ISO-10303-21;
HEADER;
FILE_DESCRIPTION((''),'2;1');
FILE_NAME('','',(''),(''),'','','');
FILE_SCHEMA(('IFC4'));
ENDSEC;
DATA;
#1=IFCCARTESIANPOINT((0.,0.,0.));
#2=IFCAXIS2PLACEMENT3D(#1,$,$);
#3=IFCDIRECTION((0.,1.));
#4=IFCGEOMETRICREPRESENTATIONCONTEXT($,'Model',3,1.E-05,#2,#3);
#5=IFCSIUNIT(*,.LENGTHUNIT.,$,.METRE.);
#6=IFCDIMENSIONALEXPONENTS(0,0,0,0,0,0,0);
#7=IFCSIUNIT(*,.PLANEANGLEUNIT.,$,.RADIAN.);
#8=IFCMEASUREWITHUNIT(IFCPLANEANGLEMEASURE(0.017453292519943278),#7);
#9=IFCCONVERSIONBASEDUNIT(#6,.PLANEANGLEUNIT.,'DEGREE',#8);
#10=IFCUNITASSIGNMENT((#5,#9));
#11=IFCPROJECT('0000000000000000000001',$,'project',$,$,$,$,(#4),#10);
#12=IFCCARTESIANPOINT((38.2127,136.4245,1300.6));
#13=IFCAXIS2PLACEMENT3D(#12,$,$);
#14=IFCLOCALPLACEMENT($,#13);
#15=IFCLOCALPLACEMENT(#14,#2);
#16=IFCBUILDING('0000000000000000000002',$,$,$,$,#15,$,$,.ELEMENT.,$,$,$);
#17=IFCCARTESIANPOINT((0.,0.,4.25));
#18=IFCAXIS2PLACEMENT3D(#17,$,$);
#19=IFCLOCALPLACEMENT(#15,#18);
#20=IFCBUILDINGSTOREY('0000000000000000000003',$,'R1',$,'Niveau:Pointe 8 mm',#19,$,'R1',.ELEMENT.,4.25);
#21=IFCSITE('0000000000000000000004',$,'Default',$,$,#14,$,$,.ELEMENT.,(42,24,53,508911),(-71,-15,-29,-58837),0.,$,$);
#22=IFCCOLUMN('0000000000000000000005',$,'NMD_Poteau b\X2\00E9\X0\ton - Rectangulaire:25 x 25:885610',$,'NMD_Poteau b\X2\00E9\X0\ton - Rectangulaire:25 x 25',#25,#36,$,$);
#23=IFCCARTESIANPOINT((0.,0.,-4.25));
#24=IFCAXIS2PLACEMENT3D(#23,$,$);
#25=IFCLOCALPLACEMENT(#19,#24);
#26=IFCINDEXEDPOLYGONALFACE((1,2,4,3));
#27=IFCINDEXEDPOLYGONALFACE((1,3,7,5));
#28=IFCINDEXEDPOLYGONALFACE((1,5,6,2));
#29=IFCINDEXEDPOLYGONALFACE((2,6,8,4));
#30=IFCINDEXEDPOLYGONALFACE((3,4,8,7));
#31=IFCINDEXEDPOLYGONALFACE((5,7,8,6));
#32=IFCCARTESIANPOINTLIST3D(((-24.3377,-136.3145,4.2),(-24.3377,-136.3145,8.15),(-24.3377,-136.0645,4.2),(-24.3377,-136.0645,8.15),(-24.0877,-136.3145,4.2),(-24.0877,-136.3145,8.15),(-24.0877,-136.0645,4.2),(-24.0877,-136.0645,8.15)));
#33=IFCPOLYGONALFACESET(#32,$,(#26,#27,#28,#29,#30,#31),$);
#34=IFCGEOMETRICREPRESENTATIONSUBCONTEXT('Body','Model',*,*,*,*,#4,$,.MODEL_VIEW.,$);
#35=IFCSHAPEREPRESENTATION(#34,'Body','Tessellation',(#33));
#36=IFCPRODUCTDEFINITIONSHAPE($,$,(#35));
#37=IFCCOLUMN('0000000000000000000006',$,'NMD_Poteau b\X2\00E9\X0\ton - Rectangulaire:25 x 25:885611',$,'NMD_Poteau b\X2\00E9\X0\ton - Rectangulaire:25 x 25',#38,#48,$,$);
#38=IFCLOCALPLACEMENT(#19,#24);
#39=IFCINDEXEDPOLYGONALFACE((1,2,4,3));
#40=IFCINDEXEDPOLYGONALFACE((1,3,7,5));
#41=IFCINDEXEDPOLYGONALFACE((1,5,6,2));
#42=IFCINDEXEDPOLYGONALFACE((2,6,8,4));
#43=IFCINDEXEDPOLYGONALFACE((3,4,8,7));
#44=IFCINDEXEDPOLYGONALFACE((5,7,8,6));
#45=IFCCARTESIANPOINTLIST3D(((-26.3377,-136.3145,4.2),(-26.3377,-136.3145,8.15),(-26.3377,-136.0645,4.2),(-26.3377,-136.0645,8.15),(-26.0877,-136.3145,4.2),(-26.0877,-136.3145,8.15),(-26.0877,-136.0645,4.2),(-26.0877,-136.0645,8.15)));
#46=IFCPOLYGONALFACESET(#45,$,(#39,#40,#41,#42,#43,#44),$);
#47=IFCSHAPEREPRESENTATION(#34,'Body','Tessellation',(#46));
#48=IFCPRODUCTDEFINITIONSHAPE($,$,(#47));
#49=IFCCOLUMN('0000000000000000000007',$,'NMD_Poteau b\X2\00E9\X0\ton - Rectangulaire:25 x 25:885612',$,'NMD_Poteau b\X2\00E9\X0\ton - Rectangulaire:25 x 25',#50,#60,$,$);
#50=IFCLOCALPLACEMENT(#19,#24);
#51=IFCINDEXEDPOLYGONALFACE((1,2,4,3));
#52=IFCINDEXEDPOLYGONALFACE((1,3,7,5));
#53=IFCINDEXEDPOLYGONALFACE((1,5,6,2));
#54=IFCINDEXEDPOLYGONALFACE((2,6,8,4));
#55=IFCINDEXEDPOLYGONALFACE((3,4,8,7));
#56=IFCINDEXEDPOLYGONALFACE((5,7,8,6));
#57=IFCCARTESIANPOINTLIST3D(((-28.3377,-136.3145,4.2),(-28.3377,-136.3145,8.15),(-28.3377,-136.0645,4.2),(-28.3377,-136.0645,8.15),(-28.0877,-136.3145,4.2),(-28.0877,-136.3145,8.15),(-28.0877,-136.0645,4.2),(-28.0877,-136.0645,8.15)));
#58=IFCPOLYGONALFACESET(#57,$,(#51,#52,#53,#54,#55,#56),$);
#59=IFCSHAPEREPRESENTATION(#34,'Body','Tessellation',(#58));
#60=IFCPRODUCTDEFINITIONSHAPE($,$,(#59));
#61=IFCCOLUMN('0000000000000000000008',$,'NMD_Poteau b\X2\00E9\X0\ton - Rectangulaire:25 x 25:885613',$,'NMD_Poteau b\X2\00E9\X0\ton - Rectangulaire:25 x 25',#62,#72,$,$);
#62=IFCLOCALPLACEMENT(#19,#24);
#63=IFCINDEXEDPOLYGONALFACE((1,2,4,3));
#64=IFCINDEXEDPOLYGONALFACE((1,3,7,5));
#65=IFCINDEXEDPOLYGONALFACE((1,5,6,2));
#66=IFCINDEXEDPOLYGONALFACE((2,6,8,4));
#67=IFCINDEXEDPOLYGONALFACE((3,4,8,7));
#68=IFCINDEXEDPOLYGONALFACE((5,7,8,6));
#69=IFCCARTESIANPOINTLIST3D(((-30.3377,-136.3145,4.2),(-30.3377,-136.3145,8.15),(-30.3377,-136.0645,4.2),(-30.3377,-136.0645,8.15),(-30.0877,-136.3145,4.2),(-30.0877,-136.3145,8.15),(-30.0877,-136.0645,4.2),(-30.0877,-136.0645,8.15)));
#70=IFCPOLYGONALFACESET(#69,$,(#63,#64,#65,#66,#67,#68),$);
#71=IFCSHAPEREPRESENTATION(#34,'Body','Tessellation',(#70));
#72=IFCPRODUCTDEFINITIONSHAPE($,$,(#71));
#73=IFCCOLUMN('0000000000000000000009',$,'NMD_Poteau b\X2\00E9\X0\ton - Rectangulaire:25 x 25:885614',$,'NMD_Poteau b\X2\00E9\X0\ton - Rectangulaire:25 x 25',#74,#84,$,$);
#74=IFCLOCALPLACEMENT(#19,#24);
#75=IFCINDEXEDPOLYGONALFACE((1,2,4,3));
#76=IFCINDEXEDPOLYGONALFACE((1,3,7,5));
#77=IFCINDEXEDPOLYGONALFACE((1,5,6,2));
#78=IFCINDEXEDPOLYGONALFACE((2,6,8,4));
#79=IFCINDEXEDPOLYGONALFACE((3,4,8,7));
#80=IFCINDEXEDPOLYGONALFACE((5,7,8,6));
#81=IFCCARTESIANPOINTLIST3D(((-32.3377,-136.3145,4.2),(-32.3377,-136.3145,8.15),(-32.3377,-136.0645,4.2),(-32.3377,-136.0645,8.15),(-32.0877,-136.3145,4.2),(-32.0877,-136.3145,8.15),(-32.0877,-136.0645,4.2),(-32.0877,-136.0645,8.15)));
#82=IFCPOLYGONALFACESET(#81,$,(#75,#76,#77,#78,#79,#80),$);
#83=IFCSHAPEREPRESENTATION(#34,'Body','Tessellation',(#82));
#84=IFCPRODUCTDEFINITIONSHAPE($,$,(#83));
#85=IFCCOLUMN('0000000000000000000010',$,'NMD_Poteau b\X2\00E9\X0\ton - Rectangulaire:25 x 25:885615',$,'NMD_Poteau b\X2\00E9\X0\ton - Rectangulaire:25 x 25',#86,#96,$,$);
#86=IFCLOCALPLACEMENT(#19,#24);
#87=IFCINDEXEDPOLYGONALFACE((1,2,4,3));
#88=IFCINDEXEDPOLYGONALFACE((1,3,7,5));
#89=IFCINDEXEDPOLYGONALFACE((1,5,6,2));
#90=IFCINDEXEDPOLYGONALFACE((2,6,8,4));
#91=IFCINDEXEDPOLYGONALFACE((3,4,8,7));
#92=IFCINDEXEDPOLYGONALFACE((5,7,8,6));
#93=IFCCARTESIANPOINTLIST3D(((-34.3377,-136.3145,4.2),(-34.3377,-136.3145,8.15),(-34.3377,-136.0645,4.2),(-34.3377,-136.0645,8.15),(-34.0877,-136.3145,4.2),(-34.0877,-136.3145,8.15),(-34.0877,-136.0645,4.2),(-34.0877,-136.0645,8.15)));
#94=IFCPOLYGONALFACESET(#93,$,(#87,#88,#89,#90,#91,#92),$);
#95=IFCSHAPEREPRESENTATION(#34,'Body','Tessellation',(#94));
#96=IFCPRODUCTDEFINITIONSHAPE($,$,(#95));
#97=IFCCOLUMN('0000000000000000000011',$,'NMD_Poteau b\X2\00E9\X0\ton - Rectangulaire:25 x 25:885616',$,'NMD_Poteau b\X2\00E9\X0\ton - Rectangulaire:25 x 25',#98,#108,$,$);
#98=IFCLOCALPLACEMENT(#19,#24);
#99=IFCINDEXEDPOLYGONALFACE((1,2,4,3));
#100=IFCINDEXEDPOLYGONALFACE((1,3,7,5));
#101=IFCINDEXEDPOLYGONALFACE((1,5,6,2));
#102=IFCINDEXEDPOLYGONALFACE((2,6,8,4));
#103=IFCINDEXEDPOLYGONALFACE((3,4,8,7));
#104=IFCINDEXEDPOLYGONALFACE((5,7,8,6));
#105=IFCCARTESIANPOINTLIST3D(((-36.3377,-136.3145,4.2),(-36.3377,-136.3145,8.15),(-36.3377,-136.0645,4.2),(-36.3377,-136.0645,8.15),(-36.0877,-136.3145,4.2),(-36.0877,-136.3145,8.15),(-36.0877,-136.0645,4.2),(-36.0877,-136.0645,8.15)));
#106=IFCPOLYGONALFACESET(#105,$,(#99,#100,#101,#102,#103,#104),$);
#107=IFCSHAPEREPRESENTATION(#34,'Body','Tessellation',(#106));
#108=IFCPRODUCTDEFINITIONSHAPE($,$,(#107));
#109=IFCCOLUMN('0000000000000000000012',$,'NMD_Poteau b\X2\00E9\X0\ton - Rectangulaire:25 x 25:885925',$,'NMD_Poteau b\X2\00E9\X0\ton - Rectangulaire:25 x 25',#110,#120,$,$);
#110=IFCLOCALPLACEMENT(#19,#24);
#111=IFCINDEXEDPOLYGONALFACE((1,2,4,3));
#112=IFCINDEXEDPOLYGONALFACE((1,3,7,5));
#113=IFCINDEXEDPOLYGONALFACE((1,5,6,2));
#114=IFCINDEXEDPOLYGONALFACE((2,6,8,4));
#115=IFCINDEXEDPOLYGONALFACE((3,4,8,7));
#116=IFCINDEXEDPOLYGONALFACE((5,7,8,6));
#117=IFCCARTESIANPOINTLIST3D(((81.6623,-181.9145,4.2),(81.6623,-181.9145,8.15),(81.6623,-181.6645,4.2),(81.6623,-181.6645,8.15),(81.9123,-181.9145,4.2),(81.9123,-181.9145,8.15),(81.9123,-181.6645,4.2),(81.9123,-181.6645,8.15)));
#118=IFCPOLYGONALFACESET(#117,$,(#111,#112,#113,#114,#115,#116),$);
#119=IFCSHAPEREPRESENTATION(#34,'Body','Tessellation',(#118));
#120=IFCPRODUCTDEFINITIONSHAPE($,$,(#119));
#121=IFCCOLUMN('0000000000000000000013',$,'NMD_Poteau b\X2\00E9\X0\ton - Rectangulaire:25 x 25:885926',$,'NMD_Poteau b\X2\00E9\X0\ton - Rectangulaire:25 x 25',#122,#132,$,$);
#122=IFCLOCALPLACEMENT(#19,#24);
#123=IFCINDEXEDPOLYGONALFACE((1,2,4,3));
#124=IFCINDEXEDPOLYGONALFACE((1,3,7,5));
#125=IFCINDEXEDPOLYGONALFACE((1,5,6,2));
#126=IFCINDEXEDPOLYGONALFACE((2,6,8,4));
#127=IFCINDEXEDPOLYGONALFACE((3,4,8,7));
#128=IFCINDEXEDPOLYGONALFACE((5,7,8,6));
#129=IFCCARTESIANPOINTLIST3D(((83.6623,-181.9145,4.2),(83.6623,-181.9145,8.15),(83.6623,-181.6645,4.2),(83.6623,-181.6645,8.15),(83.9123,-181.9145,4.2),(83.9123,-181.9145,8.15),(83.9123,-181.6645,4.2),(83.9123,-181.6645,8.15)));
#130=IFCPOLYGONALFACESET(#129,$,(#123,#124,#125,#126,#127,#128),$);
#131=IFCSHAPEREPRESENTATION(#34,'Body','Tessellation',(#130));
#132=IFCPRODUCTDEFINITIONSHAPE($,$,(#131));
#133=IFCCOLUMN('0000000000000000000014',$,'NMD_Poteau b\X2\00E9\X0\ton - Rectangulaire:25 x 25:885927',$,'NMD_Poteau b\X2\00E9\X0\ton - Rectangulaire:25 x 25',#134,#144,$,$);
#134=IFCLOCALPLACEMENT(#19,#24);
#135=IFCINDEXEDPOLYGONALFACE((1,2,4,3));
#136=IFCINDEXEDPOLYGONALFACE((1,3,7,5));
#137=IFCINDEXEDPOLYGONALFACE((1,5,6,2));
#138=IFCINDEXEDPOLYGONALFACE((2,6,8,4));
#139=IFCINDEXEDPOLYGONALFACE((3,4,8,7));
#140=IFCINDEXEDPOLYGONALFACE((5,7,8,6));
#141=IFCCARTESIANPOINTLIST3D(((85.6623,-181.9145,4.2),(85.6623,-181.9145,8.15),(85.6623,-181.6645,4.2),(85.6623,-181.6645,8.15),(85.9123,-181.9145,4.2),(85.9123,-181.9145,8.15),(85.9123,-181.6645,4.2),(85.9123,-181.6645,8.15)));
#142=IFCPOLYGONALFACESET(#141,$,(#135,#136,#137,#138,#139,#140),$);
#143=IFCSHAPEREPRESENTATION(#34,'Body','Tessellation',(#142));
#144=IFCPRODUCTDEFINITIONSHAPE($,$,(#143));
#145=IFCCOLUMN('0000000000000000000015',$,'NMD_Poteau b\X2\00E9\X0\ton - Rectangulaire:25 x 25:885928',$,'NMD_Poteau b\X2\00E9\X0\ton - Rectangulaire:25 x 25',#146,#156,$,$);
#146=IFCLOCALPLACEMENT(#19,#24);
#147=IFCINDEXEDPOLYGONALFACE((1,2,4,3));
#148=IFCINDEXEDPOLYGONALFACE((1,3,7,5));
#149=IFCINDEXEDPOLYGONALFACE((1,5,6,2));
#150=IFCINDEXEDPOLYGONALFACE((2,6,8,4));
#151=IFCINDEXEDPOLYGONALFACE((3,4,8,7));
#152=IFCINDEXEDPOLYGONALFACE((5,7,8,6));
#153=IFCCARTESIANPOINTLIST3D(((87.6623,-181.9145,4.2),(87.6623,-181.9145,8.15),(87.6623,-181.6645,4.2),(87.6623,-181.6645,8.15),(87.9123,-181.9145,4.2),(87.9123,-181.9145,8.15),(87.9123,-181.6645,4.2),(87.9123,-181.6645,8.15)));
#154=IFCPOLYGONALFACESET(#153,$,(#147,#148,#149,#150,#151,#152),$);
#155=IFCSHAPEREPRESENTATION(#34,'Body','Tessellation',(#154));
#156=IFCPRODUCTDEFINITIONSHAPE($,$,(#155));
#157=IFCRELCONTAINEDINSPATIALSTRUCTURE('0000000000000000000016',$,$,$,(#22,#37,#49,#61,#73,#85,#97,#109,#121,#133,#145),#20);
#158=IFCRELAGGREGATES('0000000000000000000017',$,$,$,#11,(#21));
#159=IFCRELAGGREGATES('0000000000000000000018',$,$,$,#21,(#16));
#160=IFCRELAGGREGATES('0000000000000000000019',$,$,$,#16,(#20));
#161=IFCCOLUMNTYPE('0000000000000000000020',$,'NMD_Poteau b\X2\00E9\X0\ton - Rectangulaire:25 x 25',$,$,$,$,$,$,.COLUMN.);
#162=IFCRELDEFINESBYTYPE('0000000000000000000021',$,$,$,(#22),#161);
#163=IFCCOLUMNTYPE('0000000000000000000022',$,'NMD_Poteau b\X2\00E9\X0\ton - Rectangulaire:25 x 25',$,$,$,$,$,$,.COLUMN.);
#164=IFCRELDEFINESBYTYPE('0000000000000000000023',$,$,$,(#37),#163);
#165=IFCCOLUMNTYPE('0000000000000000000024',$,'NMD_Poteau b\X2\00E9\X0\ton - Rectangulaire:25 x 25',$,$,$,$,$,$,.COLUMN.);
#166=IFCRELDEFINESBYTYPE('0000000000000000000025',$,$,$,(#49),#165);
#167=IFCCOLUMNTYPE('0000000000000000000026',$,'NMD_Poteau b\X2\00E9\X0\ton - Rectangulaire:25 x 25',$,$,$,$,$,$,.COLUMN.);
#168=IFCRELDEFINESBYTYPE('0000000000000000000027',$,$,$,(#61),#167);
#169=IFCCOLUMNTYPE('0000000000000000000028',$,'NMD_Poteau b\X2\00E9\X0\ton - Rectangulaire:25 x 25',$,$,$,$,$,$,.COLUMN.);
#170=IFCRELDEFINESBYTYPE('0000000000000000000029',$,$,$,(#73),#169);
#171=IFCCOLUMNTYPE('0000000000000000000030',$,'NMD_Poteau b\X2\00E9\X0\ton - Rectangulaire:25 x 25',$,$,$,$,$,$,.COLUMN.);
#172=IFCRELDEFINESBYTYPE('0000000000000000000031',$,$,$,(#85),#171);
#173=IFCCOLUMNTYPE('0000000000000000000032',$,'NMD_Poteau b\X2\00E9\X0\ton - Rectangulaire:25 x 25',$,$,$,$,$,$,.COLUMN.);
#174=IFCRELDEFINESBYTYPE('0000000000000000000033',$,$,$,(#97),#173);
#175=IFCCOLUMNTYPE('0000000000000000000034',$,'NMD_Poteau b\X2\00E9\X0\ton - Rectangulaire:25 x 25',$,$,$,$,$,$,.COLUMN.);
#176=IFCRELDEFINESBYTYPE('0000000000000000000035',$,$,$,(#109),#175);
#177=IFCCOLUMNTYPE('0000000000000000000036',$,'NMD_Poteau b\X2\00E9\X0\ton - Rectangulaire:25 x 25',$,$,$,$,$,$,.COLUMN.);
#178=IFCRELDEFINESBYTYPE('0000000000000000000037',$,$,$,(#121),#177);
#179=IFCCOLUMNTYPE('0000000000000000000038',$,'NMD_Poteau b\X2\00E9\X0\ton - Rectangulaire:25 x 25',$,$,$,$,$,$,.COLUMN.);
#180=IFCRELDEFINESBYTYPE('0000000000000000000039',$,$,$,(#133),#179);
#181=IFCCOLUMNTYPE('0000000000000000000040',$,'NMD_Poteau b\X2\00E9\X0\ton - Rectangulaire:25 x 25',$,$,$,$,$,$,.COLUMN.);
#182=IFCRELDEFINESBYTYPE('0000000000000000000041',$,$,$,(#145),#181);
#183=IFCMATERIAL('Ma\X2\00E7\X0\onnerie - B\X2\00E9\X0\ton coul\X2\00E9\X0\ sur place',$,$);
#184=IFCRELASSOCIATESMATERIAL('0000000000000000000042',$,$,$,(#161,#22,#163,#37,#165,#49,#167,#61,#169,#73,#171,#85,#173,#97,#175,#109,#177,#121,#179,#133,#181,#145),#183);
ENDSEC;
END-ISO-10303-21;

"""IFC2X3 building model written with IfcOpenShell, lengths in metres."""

from ifc_helpers import new_model, entity, si_unit, converted_unit, direction, frame, frame_2d, origin, place, context, subcontext, project, spatial, rectangle, extrude, source, transform, mapped, material, type_object, type_shapes, element, save


model = new_model("IFC2X3")

# Units and contexts
model_context = context("Model", 3, precision=1e-05, world=origin(), true_north=direction((0.0, 1.0)))
body_context = subcontext(model_context, "Body", "Model", "MODEL_VIEW")
ifc_project = project(units=[si_unit("LENGTHUNIT", "METRE"), converted_unit("PLANEANGLEUNIT", "DEGREE", entity("IfcPlaneAngleMeasure", 0.017453292519943278), si_unit("PLANEANGLEUNIT", "RADIAN"), dimensions=[0, 0, 0, 0, 0, 0, 0])], contexts=[model_context])

# Site, building, storey
site_placement = place(None, frame((38.2127, 136.4245, 1300.6)))
site = spatial("IfcSite", under=ifc_project, at=site_placement, Name="Default", CompositionType="ELEMENT", RefLatitude=(42, 24, 53, 508911), RefLongitude=(-71, -15, -29, -58837), RefElevation=0.0)
building_placement = place(site_placement, origin())
building = spatial("IfcBuilding", under=site, at=building_placement, CompositionType="ELEMENT")
storey_placement = place(building_placement, frame((0.0, 0.0, 4.25)))
storey = spatial("IfcBuildingStorey", under=building, at=storey_placement, Name="R1", ObjectType="Niveau:Pointe 8 mm", LongName="R1", CompositionType="ELEMENT", Elevation=4.25)

# Columns
ifc_material = material(Name="Maçonnerie - Béton coulé sur place")
column_type_1 = type_object("IfcColumnType", Name="NMD_Poteau béton - Rectangulaire:25 x 25", PredefinedType="COLUMN", material=ifc_material)
shared_shape_1 = source(origin(), body_context, "Body", "SweptSolid", [
    extrude(rectangle(XDim=0.25, YDim=0.25, at=frame_2d((0.0, 0.0), x_axis=(1.0, 0.0))), frame((-24.2127, -136.1895, 4.2), z_axis=(0.0, 0.0, 1.0), x_axis=(-1.0, 0.0, 0.0)), (0.0, 0.0, 1.0), 3.95),
])
type_shapes(column_type_1, [shared_shape_1])
column_1_placement = place(storey_placement, frame((0.0, 0.0, -4.25)))
element("IfcColumn", 1, at=column_1_placement, inside=storey, type_object=column_type_1, material=ifc_material, Name="NMD_Poteau béton - Rectangulaire:25 x 25:885610", ObjectType="NMD_Poteau béton - Rectangulaire:25 x 25", context=body_context, shape_type="MappedRepresentation", body=[
    mapped(shared_shape_1, transform((0.0, 0.0, 0.0), scale=1.0)),
])
column_type_2 = type_object("IfcColumnType", Name="NMD_Poteau béton - Rectangulaire:25 x 25", PredefinedType="COLUMN", material=ifc_material)
shared_shape_2 = source(origin(), body_context, "Body", "SweptSolid", [
    extrude(rectangle(XDim=0.25, YDim=0.25, at=frame_2d((0.0, 0.0), x_axis=(1.0, 0.0))), frame((-26.2127, -136.1895, 4.2), z_axis=(0.0, 0.0, 1.0), x_axis=(-1.0, 0.0, 0.0)), (0.0, 0.0, 1.0), 3.95),
])
type_shapes(column_type_2, [shared_shape_2])
column_2_placement = place(storey_placement, frame((0.0, 0.0, -4.25)))
element("IfcColumn", 2, at=column_2_placement, inside=storey, type_object=column_type_2, material=ifc_material, Name="NMD_Poteau béton - Rectangulaire:25 x 25:885611", ObjectType="NMD_Poteau béton - Rectangulaire:25 x 25", context=body_context, shape_type="MappedRepresentation", body=[
    mapped(shared_shape_2, transform((0.0, 0.0, 0.0), scale=1.0)),
])
column_type_3 = type_object("IfcColumnType", Name="NMD_Poteau béton - Rectangulaire:25 x 25", PredefinedType="COLUMN", material=ifc_material)
shared_shape_3 = source(origin(), body_context, "Body", "SweptSolid", [
    extrude(rectangle(XDim=0.25, YDim=0.25, at=frame_2d((0.0, 0.0), x_axis=(1.0, 0.0))), frame((-28.2127, -136.1895, 4.2), z_axis=(0.0, 0.0, 1.0), x_axis=(-1.0, 0.0, 0.0)), (0.0, 0.0, 1.0), 3.95),
])
type_shapes(column_type_3, [shared_shape_3])
column_3_placement = place(storey_placement, frame((0.0, 0.0, -4.25)))
element("IfcColumn", 3, at=column_3_placement, inside=storey, type_object=column_type_3, material=ifc_material, Name="NMD_Poteau béton - Rectangulaire:25 x 25:885612", ObjectType="NMD_Poteau béton - Rectangulaire:25 x 25", context=body_context, shape_type="MappedRepresentation", body=[
    mapped(shared_shape_3, transform((0.0, 0.0, 0.0), scale=1.0)),
])
column_type_4 = type_object("IfcColumnType", Name="NMD_Poteau béton - Rectangulaire:25 x 25", PredefinedType="COLUMN", material=ifc_material)
shared_shape_4 = source(origin(), body_context, "Body", "SweptSolid", [
    extrude(rectangle(XDim=0.25, YDim=0.25, at=frame_2d((0.0, 0.0), x_axis=(1.0, 0.0))), frame((-30.2127, -136.1895, 4.2), z_axis=(0.0, 0.0, 1.0), x_axis=(-1.0, 0.0, 0.0)), (0.0, 0.0, 1.0), 3.95),
])
type_shapes(column_type_4, [shared_shape_4])
column_4_placement = place(storey_placement, frame((0.0, 0.0, -4.25)))
element("IfcColumn", 4, at=column_4_placement, inside=storey, type_object=column_type_4, material=ifc_material, Name="NMD_Poteau béton - Rectangulaire:25 x 25:885613", ObjectType="NMD_Poteau béton - Rectangulaire:25 x 25", context=body_context, shape_type="MappedRepresentation", body=[
    mapped(shared_shape_4, transform((0.0, 0.0, 0.0), scale=1.0)),
])
column_type_5 = type_object("IfcColumnType", Name="NMD_Poteau béton - Rectangulaire:25 x 25", PredefinedType="COLUMN", material=ifc_material)
shared_shape_5 = source(origin(), body_context, "Body", "SweptSolid", [
    extrude(rectangle(XDim=0.25, YDim=0.25, at=frame_2d((0.0, 0.0), x_axis=(1.0, 0.0))), frame((-32.2127, -136.1895, 4.2), z_axis=(0.0, 0.0, 1.0), x_axis=(-1.0, 0.0, 0.0)), (0.0, 0.0, 1.0), 3.95),
])
type_shapes(column_type_5, [shared_shape_5])
column_5_placement = place(storey_placement, frame((0.0, 0.0, -4.25)))
element("IfcColumn", 5, at=column_5_placement, inside=storey, type_object=column_type_5, material=ifc_material, Name="NMD_Poteau béton - Rectangulaire:25 x 25:885614", ObjectType="NMD_Poteau béton - Rectangulaire:25 x 25", context=body_context, shape_type="MappedRepresentation", body=[
    mapped(shared_shape_5, transform((0.0, 0.0, 0.0), scale=1.0)),
])
column_type_6 = type_object("IfcColumnType", Name="NMD_Poteau béton - Rectangulaire:25 x 25", PredefinedType="COLUMN", material=ifc_material)
shared_shape_6 = source(origin(), body_context, "Body", "SweptSolid", [
    extrude(rectangle(XDim=0.25, YDim=0.25, at=frame_2d((0.0, 0.0), x_axis=(1.0, 0.0))), frame((-34.2127, -136.1895, 4.2), z_axis=(0.0, 0.0, 1.0), x_axis=(-1.0, 0.0, 0.0)), (0.0, 0.0, 1.0), 3.95),
])
type_shapes(column_type_6, [shared_shape_6])
column_6_placement = place(storey_placement, frame((0.0, 0.0, -4.25)))
element("IfcColumn", 6, at=column_6_placement, inside=storey, type_object=column_type_6, material=ifc_material, Name="NMD_Poteau béton - Rectangulaire:25 x 25:885615", ObjectType="NMD_Poteau béton - Rectangulaire:25 x 25", context=body_context, shape_type="MappedRepresentation", body=[
    mapped(shared_shape_6, transform((0.0, 0.0, 0.0), scale=1.0)),
])
column_type_7 = type_object("IfcColumnType", Name="NMD_Poteau béton - Rectangulaire:25 x 25", PredefinedType="COLUMN", material=ifc_material)
shared_shape_7 = source(origin(), body_context, "Body", "SweptSolid", [
    extrude(rectangle(XDim=0.25, YDim=0.25, at=frame_2d((0.0, 0.0), x_axis=(1.0, 0.0))), frame((-36.2127, -136.1895, 4.2), z_axis=(0.0, 0.0, 1.0), x_axis=(-1.0, 0.0, 0.0)), (0.0, 0.0, 1.0), 3.95),
])
type_shapes(column_type_7, [shared_shape_7])
column_7_placement = place(storey_placement, frame((0.0, 0.0, -4.25)))
element("IfcColumn", 7, at=column_7_placement, inside=storey, type_object=column_type_7, material=ifc_material, Name="NMD_Poteau béton - Rectangulaire:25 x 25:885616", ObjectType="NMD_Poteau béton - Rectangulaire:25 x 25", context=body_context, shape_type="MappedRepresentation", body=[
    mapped(shared_shape_7, transform((0.0, 0.0, 0.0), scale=1.0)),
])
column_type_8 = type_object("IfcColumnType", Name="NMD_Poteau béton - Rectangulaire:25 x 25", PredefinedType="COLUMN", material=ifc_material)
shared_shape_8 = source(origin(), body_context, "Body", "SweptSolid", [
    extrude(rectangle(XDim=0.25, YDim=0.25, at=frame_2d((0.0, 0.0), x_axis=(1.0, 0.0))), frame((81.7873, -181.7895, 4.2), z_axis=(0.0, 0.0, 1.0), x_axis=(-1.0, 0.0, 0.0)), (0.0, 0.0, 1.0), 3.95),
])
type_shapes(column_type_8, [shared_shape_8])
column_8_placement = place(storey_placement, frame((0.0, 0.0, -4.25)))
element("IfcColumn", 8, at=column_8_placement, inside=storey, type_object=column_type_8, material=ifc_material, Name="NMD_Poteau béton - Rectangulaire:25 x 25:885925", ObjectType="NMD_Poteau béton - Rectangulaire:25 x 25", context=body_context, shape_type="MappedRepresentation", body=[
    mapped(shared_shape_8, transform((0.0, 0.0, 0.0), scale=1.0)),
])
column_type_9 = type_object("IfcColumnType", Name="NMD_Poteau béton - Rectangulaire:25 x 25", PredefinedType="COLUMN", material=ifc_material)
shared_shape_9 = source(origin(), body_context, "Body", "SweptSolid", [
    extrude(rectangle(XDim=0.25, YDim=0.25, at=frame_2d((0.0, 0.0), x_axis=(1.0, 0.0))), frame((83.7873, -181.7895, 4.2), z_axis=(0.0, 0.0, 1.0), x_axis=(-1.0, 0.0, 0.0)), (0.0, 0.0, 1.0), 3.95),
])
type_shapes(column_type_9, [shared_shape_9])
column_9_placement = place(storey_placement, frame((0.0, 0.0, -4.25)))
element("IfcColumn", 9, at=column_9_placement, inside=storey, type_object=column_type_9, material=ifc_material, Name="NMD_Poteau béton - Rectangulaire:25 x 25:885926", ObjectType="NMD_Poteau béton - Rectangulaire:25 x 25", context=body_context, shape_type="MappedRepresentation", body=[
    mapped(shared_shape_9, transform((0.0, 0.0, 0.0), scale=1.0)),
])
column_type_10 = type_object("IfcColumnType", Name="NMD_Poteau béton - Rectangulaire:25 x 25", PredefinedType="COLUMN", material=ifc_material)
shared_shape_10 = source(origin(), body_context, "Body", "SweptSolid", [
    extrude(rectangle(XDim=0.25, YDim=0.25, at=frame_2d((0.0, 0.0), x_axis=(1.0, 0.0))), frame((85.7873, -181.7895, 4.2), z_axis=(0.0, 0.0, 1.0), x_axis=(-1.0, 0.0, 0.0)), (0.0, 0.0, 1.0), 3.95),
])
type_shapes(column_type_10, [shared_shape_10])
column_10_placement = place(storey_placement, frame((0.0, 0.0, -4.25)))
element("IfcColumn", 10, at=column_10_placement, inside=storey, type_object=column_type_10, material=ifc_material, Name="NMD_Poteau béton - Rectangulaire:25 x 25:885927", ObjectType="NMD_Poteau béton - Rectangulaire:25 x 25", context=body_context, shape_type="MappedRepresentation", body=[
    mapped(shared_shape_10, transform((0.0, 0.0, 0.0), scale=1.0)),
])
column_type_11 = type_object("IfcColumnType", Name="NMD_Poteau béton - Rectangulaire:25 x 25", PredefinedType="COLUMN", material=ifc_material)
shared_shape_11 = source(origin(), body_context, "Body", "SweptSolid", [
    extrude(rectangle(XDim=0.25, YDim=0.25, at=frame_2d((0.0, 0.0), x_axis=(1.0, 0.0))), frame((87.7873, -181.7895, 4.2), z_axis=(0.0, 0.0, 1.0), x_axis=(-1.0, 0.0, 0.0)), (0.0, 0.0, 1.0), 3.95),
])
type_shapes(column_type_11, [shared_shape_11])
column_11_placement = place(storey_placement, frame((0.0, 0.0, -4.25)))
element("IfcColumn", 11, at=column_11_placement, inside=storey, type_object=column_type_11, material=ifc_material, Name="NMD_Poteau béton - Rectangulaire:25 x 25:885928", ObjectType="NMD_Poteau béton - Rectangulaire:25 x 25", context=body_context, shape_type="MappedRepresentation", body=[
    mapped(shared_shape_11, transform((0.0, 0.0, 0.0), scale=1.0)),
])

save(model, "model.ifc")
